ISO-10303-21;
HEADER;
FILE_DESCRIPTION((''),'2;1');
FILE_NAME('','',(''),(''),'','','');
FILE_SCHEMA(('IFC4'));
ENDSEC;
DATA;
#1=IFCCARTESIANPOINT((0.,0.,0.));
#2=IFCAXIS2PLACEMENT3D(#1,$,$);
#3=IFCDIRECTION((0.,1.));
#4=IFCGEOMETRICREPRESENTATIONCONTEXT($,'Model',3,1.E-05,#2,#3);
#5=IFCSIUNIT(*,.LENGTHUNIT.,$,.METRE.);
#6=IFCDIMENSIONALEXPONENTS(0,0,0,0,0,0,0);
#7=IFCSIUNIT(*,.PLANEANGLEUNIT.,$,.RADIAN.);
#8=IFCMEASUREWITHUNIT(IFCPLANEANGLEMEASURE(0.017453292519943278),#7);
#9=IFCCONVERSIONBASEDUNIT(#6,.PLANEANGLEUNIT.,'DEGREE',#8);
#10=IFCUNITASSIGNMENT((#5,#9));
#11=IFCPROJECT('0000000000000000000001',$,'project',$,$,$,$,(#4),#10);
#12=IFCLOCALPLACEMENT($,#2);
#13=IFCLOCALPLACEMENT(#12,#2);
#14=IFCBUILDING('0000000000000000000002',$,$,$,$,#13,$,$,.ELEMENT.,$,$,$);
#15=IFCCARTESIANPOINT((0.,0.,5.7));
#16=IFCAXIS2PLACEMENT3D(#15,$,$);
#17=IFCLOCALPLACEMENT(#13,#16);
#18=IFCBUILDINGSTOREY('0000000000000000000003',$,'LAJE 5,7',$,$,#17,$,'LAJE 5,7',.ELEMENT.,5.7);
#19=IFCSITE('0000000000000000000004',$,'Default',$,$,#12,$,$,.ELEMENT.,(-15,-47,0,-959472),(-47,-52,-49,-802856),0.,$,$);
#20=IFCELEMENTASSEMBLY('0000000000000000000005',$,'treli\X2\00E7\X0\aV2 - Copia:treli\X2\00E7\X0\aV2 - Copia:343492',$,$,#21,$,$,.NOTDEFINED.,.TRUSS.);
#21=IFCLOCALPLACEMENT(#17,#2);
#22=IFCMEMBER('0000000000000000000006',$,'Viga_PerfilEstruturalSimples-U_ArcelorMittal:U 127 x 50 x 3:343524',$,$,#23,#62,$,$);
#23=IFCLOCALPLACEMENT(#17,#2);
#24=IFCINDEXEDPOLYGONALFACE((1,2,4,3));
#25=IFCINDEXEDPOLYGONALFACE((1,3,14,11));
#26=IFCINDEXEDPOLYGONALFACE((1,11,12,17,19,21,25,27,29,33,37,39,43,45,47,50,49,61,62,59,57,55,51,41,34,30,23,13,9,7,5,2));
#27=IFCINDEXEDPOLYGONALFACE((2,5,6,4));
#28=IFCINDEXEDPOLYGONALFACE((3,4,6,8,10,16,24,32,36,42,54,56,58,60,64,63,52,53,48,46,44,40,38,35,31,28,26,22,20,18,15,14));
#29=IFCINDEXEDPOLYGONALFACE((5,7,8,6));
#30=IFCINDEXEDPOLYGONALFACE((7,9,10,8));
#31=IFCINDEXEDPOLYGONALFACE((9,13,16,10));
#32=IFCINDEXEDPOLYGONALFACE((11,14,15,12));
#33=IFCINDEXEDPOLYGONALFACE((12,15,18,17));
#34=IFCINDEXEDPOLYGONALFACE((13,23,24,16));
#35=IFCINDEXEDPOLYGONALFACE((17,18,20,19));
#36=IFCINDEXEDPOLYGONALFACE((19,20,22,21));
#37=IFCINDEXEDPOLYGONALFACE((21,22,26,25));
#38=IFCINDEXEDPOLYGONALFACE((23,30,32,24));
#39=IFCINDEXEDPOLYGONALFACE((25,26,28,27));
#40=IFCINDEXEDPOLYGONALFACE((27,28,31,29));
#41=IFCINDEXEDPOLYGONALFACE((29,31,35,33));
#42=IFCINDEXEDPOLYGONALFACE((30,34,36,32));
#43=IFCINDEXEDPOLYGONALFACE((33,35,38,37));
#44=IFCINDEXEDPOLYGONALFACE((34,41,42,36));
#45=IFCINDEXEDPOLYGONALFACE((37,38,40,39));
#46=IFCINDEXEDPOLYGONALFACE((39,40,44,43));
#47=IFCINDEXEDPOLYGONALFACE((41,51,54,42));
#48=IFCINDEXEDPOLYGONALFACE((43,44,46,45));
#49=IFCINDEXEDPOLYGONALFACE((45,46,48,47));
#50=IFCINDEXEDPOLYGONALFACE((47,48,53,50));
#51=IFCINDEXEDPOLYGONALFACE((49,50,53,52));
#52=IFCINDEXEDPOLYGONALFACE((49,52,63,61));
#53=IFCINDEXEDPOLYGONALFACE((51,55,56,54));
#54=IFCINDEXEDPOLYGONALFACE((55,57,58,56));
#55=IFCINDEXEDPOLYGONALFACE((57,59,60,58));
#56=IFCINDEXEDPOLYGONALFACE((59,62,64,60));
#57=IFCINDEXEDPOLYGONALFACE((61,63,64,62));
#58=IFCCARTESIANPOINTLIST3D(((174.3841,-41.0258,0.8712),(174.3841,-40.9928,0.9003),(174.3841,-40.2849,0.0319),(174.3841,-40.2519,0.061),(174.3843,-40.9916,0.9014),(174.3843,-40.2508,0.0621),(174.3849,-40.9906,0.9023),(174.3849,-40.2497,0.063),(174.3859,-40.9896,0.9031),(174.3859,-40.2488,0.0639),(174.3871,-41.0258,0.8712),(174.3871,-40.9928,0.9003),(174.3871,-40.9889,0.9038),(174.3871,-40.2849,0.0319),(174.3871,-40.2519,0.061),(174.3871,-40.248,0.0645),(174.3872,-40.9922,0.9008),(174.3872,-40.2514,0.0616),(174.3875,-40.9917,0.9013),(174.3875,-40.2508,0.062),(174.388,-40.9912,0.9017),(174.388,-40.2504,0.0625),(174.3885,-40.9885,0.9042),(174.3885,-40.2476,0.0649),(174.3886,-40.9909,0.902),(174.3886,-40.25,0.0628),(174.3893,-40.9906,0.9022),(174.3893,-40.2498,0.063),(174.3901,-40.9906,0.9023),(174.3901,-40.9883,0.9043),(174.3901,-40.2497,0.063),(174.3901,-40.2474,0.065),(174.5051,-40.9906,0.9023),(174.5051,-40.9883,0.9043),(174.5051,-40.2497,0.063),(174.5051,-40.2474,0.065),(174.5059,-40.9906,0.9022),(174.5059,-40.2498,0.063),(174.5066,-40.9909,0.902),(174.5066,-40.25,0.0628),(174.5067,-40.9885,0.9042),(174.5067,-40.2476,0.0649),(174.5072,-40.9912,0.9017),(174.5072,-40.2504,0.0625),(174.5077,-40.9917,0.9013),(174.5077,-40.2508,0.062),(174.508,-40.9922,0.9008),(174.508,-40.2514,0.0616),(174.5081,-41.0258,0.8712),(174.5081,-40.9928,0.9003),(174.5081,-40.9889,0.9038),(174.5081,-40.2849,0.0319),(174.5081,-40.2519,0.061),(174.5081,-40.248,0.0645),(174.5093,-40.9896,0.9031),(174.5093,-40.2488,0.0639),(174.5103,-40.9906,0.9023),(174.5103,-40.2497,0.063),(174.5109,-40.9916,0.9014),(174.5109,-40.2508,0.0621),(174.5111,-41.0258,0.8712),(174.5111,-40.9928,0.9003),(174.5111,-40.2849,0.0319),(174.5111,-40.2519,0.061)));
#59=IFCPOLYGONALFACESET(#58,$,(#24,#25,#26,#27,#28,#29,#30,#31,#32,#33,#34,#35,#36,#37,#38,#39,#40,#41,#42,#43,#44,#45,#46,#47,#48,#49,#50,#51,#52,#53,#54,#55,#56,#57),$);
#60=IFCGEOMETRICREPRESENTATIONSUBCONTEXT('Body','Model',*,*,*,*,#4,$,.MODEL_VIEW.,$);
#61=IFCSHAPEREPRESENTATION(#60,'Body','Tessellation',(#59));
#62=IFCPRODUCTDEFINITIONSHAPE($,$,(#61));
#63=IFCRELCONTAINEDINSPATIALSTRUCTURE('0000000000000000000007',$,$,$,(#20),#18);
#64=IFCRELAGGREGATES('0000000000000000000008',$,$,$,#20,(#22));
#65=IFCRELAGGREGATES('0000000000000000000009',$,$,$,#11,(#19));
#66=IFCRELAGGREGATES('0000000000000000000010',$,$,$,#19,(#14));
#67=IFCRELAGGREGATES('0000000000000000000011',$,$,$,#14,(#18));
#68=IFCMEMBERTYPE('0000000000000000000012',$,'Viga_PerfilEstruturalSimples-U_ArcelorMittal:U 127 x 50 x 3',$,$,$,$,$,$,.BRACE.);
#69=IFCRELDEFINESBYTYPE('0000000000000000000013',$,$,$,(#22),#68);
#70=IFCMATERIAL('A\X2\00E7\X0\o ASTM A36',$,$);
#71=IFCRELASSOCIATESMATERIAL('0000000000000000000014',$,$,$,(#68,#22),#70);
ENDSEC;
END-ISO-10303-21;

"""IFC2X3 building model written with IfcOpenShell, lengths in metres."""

from ifc_helpers import new_model, entity, si_unit, converted_unit, direction, frame, frame_2d, origin, place, context, subcontext, project, spatial, polyline, circle_curve, parameter, trimmed, segment, composite_curve, outline, extrude, source, transform, mapped, material, type_object, type_shapes, element, aggregate, save


model = new_model("IFC2X3")

# Units and contexts
model_context = context("Model", 3, precision=1e-05, world=origin(), true_north=direction((0.0, 1.0)))
body_context = subcontext(model_context, "Body", "Model", "MODEL_VIEW")
ifc_project = project(units=[si_unit("LENGTHUNIT", "METRE"), converted_unit("PLANEANGLEUNIT", "DEGREE", entity("IfcPlaneAngleMeasure", 0.017453292519943278), si_unit("PLANEANGLEUNIT", "RADIAN"), dimensions=[0, 0, 0, 0, 0, 0, 0])], contexts=[model_context])

# Site, building, storey
site_placement = place(None, origin())
site = spatial("IfcSite", under=ifc_project, at=site_placement, Name="Default", CompositionType="ELEMENT", RefLatitude=(-15, -47, 0, -959472), RefLongitude=(-47, -52, -49, -802856), RefElevation=0.0)
building_placement = place(site_placement, origin())
building = spatial("IfcBuilding", under=site, at=building_placement, CompositionType="ELEMENT")
storey_placement = place(building_placement, frame((0.0, 0.0, 5.7)))
storey = spatial("IfcBuildingStorey", under=building, at=storey_placement, Name="LAJE 5,7", LongName="LAJE 5,7", CompositionType="ELEMENT", Elevation=5.7)

# Element assembly
assembly_1_placement = place(storey_placement, origin())
assembly_1 = element("IfcElementAssembly", 1, at=assembly_1_placement, inside=storey, Name="treliçaV2 - Copia:treliçaV2 - Copia:343492", AssemblyPlace="NOTDEFINED", PredefinedType="TRUSS")
ifc_material = material(Name="Aço ASTM A36")

# Member
member_type_1 = type_object("IfcMemberType", Name="Viga_PerfilEstruturalSimples-U_ArcelorMittal:U 127 x 50 x 3", PredefinedType="BRACE", material=ifc_material)
shared_shape_1 = source(origin(), body_context, "Body", "SweptSolid", [
    extrude(outline(composite_curve([segment(polyline([(-0.0575, -0.0192), (0.0575, -0.0192)]), True, "CONTINUOUS"), segment(trimmed(circle_curve(frame_2d((0.0575, -0.0132), x_axis=(0.0, 1.0)), 0.006), [parameter(180.0)], [parameter(270.0)], True, "PARAMETER"), True, "CONTINUOUS"), segment(polyline([(0.0635, -0.0132), (0.0635, 0.0308)]), True, "CONTINUOUS"), segment(polyline([(0.0635, 0.0308), (0.0605, 0.0308)]), True, "CONTINUOUS"), segment(polyline([(0.0605, 0.0308), (0.0605, -0.0132)]), True, "CONTINUOUS"), segment(trimmed(circle_curve(frame_2d((0.0575, -0.0132), x_axis=(0.0, 1.0)), 0.003), [parameter(180.0)], [parameter(270.0)], True, "PARAMETER"), False, "CONTINUOUS"), segment(polyline([(0.0575, -0.0162), (-0.0575, -0.0162)]), True, "CONTINUOUS"), segment(trimmed(circle_curve(frame_2d((-0.0575, -0.0132), x_axis=(0.0, 1.0)), 0.003), [parameter(90.0)], [parameter(180.0)], True, "PARAMETER"), False, "CONTINUOUS"), segment(polyline([(-0.0605, -0.0132), (-0.0605, 0.0308)]), True, "CONTINUOUS"), segment(polyline([(-0.0605, 0.0308), (-0.0635, 0.0308)]), True, "CONTINUOUS"), segment(polyline([(-0.0635, 0.0308), (-0.0635, -0.0132)]), True, "CONTINUOUS"), segment(trimmed(circle_curve(frame_2d((-0.0575, -0.0132), x_axis=(0.0, 1.0)), 0.006), [parameter(90.0)], [parameter(180.0)], True, "PARAMETER"), True, "CONTINUOUS")], self_intersect=False)), frame((-0.5514, -0.0058, 0.0), z_axis=(1.0, 0.0, 0.0), x_axis=(0.0, 0.0, -1.0)), (0.0, 0.0, 1.0), 1.1195),
])
type_shapes(member_type_1, [shared_shape_1])
member_1_placement = place(assembly_1_placement, frame((174.4476, -40.6421, 0.4744), z_axis=(-1.0, 0.0, 0.0), x_axis=(0.0, 0.661783, -0.749695)))
member_1 = element("IfcMember", 2, at=member_1_placement, type_object=member_type_1, material=ifc_material, Name="Viga_PerfilEstruturalSimples-U_ArcelorMittal:U 127 x 50 x 3:343524", context=body_context, shape_type="MappedRepresentation", body=[
    mapped(shared_shape_1, transform((0.0, 0.0, 0.0), scale=1.0)),
])
aggregate(assembly_1, [member_1])

save(model, "model.ifc")
